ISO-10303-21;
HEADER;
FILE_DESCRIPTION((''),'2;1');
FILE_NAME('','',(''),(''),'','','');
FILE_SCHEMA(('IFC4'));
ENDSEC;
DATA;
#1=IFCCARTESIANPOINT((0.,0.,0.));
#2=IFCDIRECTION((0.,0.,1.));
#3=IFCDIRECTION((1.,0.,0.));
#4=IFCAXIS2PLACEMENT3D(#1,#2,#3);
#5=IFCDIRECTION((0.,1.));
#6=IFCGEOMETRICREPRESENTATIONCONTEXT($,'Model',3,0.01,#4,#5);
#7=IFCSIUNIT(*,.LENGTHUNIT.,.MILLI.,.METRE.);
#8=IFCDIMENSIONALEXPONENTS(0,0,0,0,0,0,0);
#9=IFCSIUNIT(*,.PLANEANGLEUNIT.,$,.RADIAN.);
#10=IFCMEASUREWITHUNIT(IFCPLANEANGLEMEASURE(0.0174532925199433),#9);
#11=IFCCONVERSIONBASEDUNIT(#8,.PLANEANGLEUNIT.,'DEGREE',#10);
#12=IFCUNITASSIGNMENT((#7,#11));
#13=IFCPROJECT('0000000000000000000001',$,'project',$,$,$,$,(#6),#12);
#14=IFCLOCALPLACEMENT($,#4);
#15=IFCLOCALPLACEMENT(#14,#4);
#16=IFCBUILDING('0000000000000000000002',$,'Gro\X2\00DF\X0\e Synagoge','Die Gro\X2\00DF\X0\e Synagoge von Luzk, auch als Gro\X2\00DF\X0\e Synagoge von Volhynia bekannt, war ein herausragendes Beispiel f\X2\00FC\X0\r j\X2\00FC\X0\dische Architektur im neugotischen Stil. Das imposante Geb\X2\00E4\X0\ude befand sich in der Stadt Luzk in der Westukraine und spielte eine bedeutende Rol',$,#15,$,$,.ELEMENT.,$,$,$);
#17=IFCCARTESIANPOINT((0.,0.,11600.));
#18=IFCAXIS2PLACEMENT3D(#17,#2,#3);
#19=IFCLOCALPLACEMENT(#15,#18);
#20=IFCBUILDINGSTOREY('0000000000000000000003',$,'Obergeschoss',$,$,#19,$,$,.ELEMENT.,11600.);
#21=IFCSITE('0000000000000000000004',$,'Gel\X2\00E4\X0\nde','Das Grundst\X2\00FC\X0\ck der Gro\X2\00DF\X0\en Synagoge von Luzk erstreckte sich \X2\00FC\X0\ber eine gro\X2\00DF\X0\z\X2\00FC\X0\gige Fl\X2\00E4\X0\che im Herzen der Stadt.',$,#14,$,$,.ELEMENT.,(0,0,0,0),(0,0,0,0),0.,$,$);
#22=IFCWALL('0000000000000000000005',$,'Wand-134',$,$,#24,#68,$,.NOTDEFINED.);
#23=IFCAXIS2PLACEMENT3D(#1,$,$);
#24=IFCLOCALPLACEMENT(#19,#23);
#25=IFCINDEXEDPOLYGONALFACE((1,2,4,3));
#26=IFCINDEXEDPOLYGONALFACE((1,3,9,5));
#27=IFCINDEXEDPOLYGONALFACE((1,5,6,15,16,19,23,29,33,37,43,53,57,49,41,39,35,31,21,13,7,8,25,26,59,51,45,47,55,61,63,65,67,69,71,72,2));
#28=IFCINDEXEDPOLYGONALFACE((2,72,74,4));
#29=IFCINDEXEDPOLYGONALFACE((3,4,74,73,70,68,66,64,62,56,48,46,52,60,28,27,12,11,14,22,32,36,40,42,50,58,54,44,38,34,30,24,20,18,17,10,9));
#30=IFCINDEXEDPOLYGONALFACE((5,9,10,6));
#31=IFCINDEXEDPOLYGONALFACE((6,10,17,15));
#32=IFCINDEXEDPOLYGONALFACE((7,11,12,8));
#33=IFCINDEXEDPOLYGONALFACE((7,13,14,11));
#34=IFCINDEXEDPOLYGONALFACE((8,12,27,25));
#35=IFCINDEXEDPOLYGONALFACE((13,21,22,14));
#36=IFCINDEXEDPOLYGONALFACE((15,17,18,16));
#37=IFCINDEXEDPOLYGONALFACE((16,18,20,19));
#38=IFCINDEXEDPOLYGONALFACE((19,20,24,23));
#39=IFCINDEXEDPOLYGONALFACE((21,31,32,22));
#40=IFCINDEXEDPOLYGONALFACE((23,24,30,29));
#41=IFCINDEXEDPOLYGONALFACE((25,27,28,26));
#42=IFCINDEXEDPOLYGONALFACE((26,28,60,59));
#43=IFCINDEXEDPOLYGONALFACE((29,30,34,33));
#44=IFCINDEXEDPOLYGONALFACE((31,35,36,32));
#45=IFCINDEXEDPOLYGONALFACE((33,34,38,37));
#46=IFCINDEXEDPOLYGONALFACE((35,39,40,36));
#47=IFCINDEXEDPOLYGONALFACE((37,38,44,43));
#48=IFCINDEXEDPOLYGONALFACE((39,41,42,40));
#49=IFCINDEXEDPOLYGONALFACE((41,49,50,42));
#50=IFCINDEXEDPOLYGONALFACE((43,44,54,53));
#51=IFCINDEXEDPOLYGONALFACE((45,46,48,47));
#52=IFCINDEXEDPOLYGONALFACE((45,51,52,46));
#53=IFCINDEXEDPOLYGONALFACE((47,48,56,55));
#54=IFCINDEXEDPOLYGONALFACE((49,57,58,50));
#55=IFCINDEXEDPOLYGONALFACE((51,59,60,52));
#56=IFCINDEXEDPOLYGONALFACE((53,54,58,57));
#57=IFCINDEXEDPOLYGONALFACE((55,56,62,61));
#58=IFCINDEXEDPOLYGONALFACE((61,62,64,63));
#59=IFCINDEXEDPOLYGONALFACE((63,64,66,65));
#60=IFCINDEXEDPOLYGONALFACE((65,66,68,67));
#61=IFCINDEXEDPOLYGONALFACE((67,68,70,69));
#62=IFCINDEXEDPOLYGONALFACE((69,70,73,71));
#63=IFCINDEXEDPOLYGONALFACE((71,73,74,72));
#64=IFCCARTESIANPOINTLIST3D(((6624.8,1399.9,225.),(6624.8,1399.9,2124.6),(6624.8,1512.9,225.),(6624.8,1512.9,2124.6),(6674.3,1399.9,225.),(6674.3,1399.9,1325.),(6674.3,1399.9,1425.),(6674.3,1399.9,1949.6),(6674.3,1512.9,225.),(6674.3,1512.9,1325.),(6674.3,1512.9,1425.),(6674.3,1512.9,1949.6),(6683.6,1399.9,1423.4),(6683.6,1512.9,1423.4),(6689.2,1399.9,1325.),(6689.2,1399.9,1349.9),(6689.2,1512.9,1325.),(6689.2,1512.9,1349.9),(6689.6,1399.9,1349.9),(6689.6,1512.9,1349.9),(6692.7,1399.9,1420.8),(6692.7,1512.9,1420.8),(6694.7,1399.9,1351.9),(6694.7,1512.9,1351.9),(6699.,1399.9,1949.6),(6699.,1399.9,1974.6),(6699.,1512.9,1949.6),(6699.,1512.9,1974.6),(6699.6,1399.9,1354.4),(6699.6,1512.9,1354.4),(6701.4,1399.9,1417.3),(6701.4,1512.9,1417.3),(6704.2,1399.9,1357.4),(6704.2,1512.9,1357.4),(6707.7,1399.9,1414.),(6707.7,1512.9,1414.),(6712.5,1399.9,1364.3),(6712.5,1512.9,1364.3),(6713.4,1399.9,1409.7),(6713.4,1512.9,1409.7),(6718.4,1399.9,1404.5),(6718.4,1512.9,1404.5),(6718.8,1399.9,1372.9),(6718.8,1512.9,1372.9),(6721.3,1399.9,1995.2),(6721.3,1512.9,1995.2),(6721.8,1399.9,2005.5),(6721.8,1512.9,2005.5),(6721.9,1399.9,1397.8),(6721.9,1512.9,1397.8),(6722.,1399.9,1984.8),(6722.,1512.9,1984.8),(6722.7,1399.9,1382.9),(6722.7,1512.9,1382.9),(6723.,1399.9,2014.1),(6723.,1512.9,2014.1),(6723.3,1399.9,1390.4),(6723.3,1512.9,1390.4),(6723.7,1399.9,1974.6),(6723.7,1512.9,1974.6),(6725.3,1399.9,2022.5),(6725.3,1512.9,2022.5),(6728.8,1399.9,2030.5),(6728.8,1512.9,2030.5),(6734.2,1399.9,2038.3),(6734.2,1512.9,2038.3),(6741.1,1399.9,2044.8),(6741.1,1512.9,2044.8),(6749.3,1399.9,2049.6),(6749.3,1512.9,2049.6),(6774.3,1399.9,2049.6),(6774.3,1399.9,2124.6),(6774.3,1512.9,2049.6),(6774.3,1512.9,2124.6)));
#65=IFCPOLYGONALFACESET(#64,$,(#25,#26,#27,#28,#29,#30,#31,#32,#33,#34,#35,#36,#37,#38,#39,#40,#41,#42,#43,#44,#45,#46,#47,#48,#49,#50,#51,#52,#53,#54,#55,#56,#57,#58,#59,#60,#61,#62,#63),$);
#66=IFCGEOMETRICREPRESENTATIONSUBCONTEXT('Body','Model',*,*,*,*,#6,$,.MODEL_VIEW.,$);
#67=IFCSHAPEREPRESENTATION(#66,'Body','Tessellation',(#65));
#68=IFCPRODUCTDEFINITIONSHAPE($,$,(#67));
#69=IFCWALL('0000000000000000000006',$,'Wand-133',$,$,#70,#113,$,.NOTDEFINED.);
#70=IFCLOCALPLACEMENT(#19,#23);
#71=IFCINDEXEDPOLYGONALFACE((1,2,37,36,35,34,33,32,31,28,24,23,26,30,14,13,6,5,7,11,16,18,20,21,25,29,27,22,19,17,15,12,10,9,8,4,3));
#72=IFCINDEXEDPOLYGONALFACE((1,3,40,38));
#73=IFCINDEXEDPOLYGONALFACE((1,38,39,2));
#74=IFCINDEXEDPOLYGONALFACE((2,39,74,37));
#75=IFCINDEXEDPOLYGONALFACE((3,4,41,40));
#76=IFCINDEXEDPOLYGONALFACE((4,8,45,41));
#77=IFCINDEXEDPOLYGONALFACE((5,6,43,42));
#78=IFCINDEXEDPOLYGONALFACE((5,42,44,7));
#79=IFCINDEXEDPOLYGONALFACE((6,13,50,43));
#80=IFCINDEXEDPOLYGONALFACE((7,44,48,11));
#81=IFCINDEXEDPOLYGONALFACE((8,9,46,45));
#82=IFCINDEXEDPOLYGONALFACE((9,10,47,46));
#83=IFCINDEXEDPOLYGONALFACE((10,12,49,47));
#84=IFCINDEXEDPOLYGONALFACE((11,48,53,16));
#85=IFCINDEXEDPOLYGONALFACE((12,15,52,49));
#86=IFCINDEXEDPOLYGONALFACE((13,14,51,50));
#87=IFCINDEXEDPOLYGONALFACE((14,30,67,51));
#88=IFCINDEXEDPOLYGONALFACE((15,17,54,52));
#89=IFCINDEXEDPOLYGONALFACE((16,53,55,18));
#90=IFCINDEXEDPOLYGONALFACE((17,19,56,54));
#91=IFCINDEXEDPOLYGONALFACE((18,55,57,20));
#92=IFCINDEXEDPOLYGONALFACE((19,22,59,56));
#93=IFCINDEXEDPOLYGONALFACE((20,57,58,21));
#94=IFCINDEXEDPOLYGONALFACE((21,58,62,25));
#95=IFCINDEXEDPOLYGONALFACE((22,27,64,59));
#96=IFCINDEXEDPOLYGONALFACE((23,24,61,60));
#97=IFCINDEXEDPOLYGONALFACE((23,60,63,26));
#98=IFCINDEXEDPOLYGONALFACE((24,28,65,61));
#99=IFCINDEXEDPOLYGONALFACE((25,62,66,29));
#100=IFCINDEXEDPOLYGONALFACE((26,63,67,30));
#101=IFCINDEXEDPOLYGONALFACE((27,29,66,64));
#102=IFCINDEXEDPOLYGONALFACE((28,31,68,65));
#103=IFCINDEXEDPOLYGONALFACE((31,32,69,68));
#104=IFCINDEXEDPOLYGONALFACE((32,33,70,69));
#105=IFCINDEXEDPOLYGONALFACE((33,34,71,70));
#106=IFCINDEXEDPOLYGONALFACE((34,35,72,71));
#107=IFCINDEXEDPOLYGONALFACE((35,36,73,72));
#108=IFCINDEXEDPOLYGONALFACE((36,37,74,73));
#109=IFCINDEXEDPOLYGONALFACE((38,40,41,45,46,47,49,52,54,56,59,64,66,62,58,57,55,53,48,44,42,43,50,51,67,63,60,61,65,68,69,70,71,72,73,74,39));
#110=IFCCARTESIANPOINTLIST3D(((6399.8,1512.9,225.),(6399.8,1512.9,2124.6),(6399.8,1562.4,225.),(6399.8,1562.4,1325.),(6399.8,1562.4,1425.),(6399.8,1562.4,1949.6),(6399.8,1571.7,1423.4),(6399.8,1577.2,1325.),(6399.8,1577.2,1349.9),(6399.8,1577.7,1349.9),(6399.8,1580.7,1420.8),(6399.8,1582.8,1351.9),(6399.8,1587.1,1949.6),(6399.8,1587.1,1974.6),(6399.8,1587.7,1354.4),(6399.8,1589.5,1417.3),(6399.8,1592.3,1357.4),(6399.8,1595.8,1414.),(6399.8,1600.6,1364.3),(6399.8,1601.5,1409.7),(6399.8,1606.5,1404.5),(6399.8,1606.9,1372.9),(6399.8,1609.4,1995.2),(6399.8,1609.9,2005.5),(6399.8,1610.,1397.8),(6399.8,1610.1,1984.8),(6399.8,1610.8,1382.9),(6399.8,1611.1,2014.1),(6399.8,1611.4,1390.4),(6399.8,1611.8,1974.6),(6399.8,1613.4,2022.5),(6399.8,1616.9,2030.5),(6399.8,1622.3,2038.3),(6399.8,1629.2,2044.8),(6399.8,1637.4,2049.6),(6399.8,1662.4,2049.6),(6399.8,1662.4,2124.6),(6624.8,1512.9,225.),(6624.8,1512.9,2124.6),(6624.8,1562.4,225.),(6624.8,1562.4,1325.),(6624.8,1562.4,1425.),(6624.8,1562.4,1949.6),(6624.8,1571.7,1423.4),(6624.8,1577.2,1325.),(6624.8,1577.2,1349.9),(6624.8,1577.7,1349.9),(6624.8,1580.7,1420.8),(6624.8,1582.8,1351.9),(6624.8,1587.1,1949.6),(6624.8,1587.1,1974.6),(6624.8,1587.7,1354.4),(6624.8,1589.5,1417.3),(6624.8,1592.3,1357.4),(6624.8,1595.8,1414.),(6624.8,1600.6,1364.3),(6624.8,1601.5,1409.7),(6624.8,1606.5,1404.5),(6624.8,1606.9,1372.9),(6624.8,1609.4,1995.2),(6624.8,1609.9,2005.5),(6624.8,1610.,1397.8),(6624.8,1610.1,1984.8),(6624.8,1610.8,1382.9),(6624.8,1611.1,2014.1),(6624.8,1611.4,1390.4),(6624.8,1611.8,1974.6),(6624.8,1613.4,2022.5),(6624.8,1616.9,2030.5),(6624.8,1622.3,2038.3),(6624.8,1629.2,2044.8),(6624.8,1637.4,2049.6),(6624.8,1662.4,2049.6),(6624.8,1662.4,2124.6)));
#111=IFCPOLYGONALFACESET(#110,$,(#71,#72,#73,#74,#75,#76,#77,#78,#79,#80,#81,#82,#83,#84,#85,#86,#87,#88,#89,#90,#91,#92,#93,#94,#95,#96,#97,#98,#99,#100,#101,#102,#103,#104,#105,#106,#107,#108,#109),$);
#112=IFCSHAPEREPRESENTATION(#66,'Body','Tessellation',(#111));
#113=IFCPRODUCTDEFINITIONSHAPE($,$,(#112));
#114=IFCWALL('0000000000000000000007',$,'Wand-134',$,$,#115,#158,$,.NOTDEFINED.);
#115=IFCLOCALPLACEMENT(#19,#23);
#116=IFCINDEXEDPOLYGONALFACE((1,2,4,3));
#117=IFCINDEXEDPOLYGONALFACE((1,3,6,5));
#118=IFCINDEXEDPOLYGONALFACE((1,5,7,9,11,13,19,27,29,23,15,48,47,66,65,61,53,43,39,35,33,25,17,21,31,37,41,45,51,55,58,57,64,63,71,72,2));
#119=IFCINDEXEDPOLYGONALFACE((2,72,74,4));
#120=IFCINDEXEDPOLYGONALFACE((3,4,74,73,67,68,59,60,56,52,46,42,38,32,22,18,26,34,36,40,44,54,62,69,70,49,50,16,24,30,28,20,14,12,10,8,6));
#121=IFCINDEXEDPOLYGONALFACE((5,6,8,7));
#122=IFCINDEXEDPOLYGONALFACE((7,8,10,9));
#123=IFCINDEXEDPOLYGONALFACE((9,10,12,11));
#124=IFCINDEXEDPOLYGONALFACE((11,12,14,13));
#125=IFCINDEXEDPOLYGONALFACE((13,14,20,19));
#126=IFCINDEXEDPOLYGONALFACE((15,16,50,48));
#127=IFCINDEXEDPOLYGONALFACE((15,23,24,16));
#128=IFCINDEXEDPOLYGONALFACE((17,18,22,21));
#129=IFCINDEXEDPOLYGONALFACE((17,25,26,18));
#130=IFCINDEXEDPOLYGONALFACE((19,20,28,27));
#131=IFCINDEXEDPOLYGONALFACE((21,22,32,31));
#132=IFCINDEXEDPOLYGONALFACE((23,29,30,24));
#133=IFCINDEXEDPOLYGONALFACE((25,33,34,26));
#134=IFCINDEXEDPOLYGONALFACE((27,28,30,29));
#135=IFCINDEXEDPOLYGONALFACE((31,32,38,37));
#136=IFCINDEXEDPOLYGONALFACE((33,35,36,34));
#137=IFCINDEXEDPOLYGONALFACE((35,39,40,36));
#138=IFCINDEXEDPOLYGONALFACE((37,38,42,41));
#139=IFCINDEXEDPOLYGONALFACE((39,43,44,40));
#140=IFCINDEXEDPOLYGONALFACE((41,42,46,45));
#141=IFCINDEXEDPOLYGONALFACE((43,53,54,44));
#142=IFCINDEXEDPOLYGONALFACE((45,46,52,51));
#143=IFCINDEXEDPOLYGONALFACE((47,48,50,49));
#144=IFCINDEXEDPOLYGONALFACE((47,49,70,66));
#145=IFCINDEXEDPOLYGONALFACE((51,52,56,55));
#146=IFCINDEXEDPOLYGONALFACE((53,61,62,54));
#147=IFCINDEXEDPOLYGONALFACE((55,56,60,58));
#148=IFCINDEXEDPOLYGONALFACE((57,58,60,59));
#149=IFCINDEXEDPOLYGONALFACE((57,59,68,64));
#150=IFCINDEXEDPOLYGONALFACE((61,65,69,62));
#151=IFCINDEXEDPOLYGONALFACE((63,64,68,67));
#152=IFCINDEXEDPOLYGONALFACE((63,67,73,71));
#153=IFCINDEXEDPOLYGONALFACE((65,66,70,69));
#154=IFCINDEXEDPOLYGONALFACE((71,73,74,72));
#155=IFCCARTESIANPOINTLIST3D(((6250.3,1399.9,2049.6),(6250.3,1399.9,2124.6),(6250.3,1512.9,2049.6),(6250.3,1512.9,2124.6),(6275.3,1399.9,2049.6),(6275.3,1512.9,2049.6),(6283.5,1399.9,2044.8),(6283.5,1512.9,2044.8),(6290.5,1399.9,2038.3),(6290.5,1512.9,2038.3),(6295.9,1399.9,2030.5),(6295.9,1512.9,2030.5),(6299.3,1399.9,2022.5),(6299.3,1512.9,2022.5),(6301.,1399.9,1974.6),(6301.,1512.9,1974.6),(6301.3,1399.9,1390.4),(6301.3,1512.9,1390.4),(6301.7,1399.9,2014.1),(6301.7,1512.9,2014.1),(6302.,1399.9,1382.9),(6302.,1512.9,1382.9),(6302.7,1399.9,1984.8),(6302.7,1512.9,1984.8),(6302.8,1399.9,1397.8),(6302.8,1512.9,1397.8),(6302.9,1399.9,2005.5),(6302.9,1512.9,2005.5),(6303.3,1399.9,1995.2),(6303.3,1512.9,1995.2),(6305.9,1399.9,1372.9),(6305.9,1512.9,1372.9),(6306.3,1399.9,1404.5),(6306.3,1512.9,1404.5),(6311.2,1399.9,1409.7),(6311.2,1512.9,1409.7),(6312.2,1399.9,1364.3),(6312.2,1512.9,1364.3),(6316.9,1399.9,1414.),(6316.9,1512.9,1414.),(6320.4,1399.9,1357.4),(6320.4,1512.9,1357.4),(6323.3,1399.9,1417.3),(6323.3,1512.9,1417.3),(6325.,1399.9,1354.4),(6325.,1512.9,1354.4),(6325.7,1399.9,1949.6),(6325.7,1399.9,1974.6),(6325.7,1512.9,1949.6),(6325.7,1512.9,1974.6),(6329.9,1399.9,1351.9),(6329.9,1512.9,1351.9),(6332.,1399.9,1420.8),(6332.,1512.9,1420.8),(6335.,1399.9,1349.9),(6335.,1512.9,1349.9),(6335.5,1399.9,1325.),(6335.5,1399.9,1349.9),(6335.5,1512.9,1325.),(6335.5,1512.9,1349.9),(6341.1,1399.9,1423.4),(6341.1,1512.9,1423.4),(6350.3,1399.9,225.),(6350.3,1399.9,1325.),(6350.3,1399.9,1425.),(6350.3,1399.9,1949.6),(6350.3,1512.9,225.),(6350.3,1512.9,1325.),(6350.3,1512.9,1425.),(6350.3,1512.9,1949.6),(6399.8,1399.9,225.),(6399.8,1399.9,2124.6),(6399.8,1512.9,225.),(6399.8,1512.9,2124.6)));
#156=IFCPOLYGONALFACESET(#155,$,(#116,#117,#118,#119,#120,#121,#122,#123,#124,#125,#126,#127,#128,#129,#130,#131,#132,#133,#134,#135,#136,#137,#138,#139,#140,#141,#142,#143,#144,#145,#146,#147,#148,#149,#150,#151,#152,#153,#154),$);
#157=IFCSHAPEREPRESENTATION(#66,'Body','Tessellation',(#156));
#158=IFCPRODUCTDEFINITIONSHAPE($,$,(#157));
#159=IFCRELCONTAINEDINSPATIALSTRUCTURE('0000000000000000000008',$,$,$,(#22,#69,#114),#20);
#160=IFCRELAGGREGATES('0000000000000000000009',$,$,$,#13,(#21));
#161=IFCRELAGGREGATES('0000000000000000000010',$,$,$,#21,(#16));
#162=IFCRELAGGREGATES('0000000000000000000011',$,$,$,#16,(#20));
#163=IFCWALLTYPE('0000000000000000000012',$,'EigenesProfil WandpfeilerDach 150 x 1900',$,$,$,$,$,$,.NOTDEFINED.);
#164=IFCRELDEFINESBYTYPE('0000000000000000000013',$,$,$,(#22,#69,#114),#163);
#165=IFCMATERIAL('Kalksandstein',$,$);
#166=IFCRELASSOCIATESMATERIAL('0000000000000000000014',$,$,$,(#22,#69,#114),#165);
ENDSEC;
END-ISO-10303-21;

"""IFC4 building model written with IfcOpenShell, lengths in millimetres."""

from ifc_helpers import new_model, entity, si_unit, converted_unit, direction, frame, origin_with_axes, place, context, subcontext, project, spatial, line, arc, indexed_curve, outline, extrude, material, material_profile, profile_set, type_object, element, save


model = new_model("IFC4")

# Units and contexts
model_context = context("Model", 3, precision=0.01, world=origin_with_axes(), true_north=direction((0.0, 1.0)))
body_context = subcontext(model_context, "Body", "Model", "MODEL_VIEW")
ifc_project = project(units=[si_unit("LENGTHUNIT", "METRE", prefix="MILLI"), converted_unit("PLANEANGLEUNIT", "DEGREE", entity("IfcPlaneAngleMeasure", 0.0174532925199433), si_unit("PLANEANGLEUNIT", "RADIAN"), dimensions=[0, 0, 0, 0, 0, 0, 0])], contexts=[model_context])

# Site, building, storey
site_placement = place(None, origin_with_axes())
site = spatial("IfcSite", under=ifc_project, at=site_placement, Name="Gelände", Description="Das Grundstück der Großen Synagoge von Luzk erstreckte sich über eine großzügige Fläche im Herzen der Stadt.", CompositionType="ELEMENT", RefLatitude=(0, 0, 0, 0), RefLongitude=(0, 0, 0, 0), RefElevation=0.0)
building_placement = place(site_placement, origin_with_axes())
building = spatial("IfcBuilding", under=site, at=building_placement, Name="Große Synagoge", Description="Die Große Synagoge von Luzk, auch als Große Synagoge von Volhynia bekannt, war ein herausragendes Beispiel für jüdische Architektur im neugotischen Stil. Das imposante Gebäude befand sich in der Stadt Luzk in der Westukraine und spielte eine bedeutende Rol", CompositionType="ELEMENT")
storey_placement = place(building_placement, frame((0.0, 0.0, 11600.0), z_axis=(0.0, 0.0, 1.0), x_axis=(1.0, 0.0, 0.0)))
storey = spatial("IfcBuildingStorey", under=building, at=storey_placement, Name="Obergeschoss", CompositionType="ELEMENT", Elevation=11600.0)

# Walls
ifc_material_1 = material(Name="Kalksandstein")
ifc_material_profile = material_profile(ifc_material_1, outline(indexed_curve([(74.2, 1749.6), (98.9, 1749.6), (96.7, 1765.0), (97.0, 1780.5), (99.2, 1793.4), (103.9, 1805.5), (112.6, 1816.7), (124.5, 1824.6), (149.5, 1824.6), (149.5, 1899.6), (0.0, 1899.6), (0.0, 0.0), (49.5, 0.0), (49.5, 1100.0), (64.3, 1100.0), (64.3, 1124.9), (64.8, 1124.9), (72.4, 1128.1), (79.4, 1132.4), (91.1, 1143.4), (97.9, 1157.9), (98.0, 1169.2), (93.5, 1179.5), (85.8, 1187.0), (76.6, 1192.3), (63.3, 1197.2), (49.5, 1200.0), (49.5, 1724.6), (74.2, 1724.6)], segments=[line(1, 2), arc(2, 3, 4), arc(4, 5, 6), arc(6, 7, 8), line(8, 9, 10, 11, 12, 13, 14, 15, 16, 17), arc(17, 18, 19), arc(19, 20, 21), arc(21, 22, 23), arc(23, 24, 25), arc(25, 26, 27), line(27, 28, 29, 1)])), Name="Kalksandstein")
ifc_profile_set = profile_set([ifc_material_profile], Name="EigenesProfil WandpfeilerDach")
wall_type_1 = type_object("IfcWallType", Name="EigenesProfil WandpfeilerDach 150 x 1900", PredefinedType="NOTDEFINED")
wall_1_placement = place(storey_placement, frame((6624.8, 1512.9, 225.0), z_axis=(0.0, 0.0, 1.0), x_axis=(0.0, -1.0, 0.0)))
element("IfcWall", 1, at=wall_1_placement, inside=storey, type_object=wall_type_1, material=ifc_profile_set, Name="Wand-134", PredefinedType="NOTDEFINED", context=body_context, shape_type="SweptSolid", body=[
    extrude(outline(indexed_curve([(74.2, 1749.6), (98.9, 1749.6), (96.7, 1765.0), (97.0, 1780.5), (99.2, 1793.4), (103.9, 1805.5), (112.6, 1816.7), (124.5, 1824.6), (149.5, 1824.6), (149.5, 1899.6), (0.0, 1899.6), (0.0, 0.0), (49.5, 0.0), (49.5, 1100.0), (64.3, 1100.0), (64.3, 1124.9), (64.8, 1124.9), (72.4, 1128.1), (79.4, 1132.4), (91.1, 1143.4), (97.9, 1157.9), (98.0, 1169.2), (93.5, 1179.5), (85.8, 1187.0), (76.6, 1192.3), (63.3, 1197.2), (49.5, 1200.0), (49.5, 1724.6), (74.2, 1724.6)], segments=[line(1, 2), arc(2, 3, 4), arc(4, 5, 6), arc(6, 7, 8), line(8, 9, 10, 11, 12, 13, 14, 15, 16, 17), arc(17, 18, 19), arc(19, 20, 21), arc(21, 22, 23), arc(23, 24, 25), arc(25, 26, 27), line(27, 28, 29, 1)])), frame((0.0, 0.0, 0.0), z_axis=(1.0, 0.0, 0.0), x_axis=(0.0, 1.0, 0.0)), (0.0, 0.0, 1.0), 113.0),
])
wall_2_placement = place(storey_placement, frame((6399.8, 1512.9, 225.0), z_axis=(0.0, 0.0, 1.0), x_axis=(1.0, 0.0, 0.0)))
element("IfcWall", 2, at=wall_2_placement, inside=storey, type_object=wall_type_1, material=ifc_profile_set, Name="Wand-133", PredefinedType="NOTDEFINED", context=body_context, shape_type="SweptSolid", body=[
    extrude(outline(indexed_curve([(74.2, 1749.6), (98.9, 1749.6), (96.7, 1765.0), (97.0, 1780.5), (99.2, 1793.4), (103.9, 1805.5), (112.6, 1816.7), (124.5, 1824.6), (149.5, 1824.6), (149.5, 1899.6), (0.0, 1899.6), (0.0, 0.0), (49.5, 0.0), (49.5, 1100.0), (64.3, 1100.0), (64.3, 1124.9), (64.8, 1124.9), (72.4, 1128.1), (79.4, 1132.4), (91.1, 1143.4), (97.9, 1157.9), (98.0, 1169.2), (93.5, 1179.5), (85.8, 1187.0), (76.6, 1192.3), (63.3, 1197.2), (49.5, 1200.0), (49.5, 1724.6), (74.2, 1724.6)], segments=[line(1, 2), arc(2, 3, 4), arc(4, 5, 6), arc(6, 7, 8), line(8, 9, 10, 11, 12, 13, 14, 15, 16, 17), arc(17, 18, 19), arc(19, 20, 21), arc(21, 22, 23), arc(23, 24, 25), arc(25, 26, 27), line(27, 28, 29, 1)])), frame((0.0, 0.0, 0.0), z_axis=(1.0, 0.0, 0.0), x_axis=(0.0, 1.0, 0.0)), (0.0, 0.0, 1.0), 225.0),
])
wall_3_placement = place(storey_placement, frame((6399.8, 1512.9, 225.0), z_axis=(0.0, 0.0, 1.0), x_axis=(0.0, -1.0, 0.0)))
element("IfcWall", 3, at=wall_3_placement, inside=storey, type_object=wall_type_1, material=ifc_profile_set, Name="Wand-134", PredefinedType="NOTDEFINED", context=body_context, shape_type="SweptSolid", body=[
    extrude(outline(indexed_curve([(74.2, 1749.6), (98.9, 1749.6), (96.7, 1765.0), (97.0, 1780.5), (99.2, 1793.4), (103.9, 1805.5), (112.6, 1816.7), (124.5, 1824.6), (149.5, 1824.6), (149.5, 1899.6), (0.0, 1899.6), (0.0, 0.0), (49.5, 0.0), (49.5, 1100.0), (64.3, 1100.0), (64.3, 1124.9), (64.8, 1124.9), (72.4, 1128.1), (79.4, 1132.4), (91.1, 1143.4), (97.9, 1157.9), (98.0, 1169.2), (93.5, 1179.5), (85.8, 1187.0), (76.6, 1192.3), (63.3, 1197.2), (49.5, 1200.0), (49.5, 1724.6), (74.2, 1724.6)], segments=[line(1, 2), arc(2, 3, 4), arc(4, 5, 6), arc(6, 7, 8), line(8, 9, 10, 11, 12, 13, 14, 15, 16, 17), arc(17, 18, 19), arc(19, 20, 21), arc(21, 22, 23), arc(23, 24, 25), arc(25, 26, 27), line(27, 28, 29, 1)])), frame((0.0, 0.0, 0.0), z_axis=(-1.0, 0.0, 0.0), x_axis=(0.0, -1.0, 0.0)), (0.0, 0.0, -1.0), 113.0),
])

save(model, "model.ifc")
